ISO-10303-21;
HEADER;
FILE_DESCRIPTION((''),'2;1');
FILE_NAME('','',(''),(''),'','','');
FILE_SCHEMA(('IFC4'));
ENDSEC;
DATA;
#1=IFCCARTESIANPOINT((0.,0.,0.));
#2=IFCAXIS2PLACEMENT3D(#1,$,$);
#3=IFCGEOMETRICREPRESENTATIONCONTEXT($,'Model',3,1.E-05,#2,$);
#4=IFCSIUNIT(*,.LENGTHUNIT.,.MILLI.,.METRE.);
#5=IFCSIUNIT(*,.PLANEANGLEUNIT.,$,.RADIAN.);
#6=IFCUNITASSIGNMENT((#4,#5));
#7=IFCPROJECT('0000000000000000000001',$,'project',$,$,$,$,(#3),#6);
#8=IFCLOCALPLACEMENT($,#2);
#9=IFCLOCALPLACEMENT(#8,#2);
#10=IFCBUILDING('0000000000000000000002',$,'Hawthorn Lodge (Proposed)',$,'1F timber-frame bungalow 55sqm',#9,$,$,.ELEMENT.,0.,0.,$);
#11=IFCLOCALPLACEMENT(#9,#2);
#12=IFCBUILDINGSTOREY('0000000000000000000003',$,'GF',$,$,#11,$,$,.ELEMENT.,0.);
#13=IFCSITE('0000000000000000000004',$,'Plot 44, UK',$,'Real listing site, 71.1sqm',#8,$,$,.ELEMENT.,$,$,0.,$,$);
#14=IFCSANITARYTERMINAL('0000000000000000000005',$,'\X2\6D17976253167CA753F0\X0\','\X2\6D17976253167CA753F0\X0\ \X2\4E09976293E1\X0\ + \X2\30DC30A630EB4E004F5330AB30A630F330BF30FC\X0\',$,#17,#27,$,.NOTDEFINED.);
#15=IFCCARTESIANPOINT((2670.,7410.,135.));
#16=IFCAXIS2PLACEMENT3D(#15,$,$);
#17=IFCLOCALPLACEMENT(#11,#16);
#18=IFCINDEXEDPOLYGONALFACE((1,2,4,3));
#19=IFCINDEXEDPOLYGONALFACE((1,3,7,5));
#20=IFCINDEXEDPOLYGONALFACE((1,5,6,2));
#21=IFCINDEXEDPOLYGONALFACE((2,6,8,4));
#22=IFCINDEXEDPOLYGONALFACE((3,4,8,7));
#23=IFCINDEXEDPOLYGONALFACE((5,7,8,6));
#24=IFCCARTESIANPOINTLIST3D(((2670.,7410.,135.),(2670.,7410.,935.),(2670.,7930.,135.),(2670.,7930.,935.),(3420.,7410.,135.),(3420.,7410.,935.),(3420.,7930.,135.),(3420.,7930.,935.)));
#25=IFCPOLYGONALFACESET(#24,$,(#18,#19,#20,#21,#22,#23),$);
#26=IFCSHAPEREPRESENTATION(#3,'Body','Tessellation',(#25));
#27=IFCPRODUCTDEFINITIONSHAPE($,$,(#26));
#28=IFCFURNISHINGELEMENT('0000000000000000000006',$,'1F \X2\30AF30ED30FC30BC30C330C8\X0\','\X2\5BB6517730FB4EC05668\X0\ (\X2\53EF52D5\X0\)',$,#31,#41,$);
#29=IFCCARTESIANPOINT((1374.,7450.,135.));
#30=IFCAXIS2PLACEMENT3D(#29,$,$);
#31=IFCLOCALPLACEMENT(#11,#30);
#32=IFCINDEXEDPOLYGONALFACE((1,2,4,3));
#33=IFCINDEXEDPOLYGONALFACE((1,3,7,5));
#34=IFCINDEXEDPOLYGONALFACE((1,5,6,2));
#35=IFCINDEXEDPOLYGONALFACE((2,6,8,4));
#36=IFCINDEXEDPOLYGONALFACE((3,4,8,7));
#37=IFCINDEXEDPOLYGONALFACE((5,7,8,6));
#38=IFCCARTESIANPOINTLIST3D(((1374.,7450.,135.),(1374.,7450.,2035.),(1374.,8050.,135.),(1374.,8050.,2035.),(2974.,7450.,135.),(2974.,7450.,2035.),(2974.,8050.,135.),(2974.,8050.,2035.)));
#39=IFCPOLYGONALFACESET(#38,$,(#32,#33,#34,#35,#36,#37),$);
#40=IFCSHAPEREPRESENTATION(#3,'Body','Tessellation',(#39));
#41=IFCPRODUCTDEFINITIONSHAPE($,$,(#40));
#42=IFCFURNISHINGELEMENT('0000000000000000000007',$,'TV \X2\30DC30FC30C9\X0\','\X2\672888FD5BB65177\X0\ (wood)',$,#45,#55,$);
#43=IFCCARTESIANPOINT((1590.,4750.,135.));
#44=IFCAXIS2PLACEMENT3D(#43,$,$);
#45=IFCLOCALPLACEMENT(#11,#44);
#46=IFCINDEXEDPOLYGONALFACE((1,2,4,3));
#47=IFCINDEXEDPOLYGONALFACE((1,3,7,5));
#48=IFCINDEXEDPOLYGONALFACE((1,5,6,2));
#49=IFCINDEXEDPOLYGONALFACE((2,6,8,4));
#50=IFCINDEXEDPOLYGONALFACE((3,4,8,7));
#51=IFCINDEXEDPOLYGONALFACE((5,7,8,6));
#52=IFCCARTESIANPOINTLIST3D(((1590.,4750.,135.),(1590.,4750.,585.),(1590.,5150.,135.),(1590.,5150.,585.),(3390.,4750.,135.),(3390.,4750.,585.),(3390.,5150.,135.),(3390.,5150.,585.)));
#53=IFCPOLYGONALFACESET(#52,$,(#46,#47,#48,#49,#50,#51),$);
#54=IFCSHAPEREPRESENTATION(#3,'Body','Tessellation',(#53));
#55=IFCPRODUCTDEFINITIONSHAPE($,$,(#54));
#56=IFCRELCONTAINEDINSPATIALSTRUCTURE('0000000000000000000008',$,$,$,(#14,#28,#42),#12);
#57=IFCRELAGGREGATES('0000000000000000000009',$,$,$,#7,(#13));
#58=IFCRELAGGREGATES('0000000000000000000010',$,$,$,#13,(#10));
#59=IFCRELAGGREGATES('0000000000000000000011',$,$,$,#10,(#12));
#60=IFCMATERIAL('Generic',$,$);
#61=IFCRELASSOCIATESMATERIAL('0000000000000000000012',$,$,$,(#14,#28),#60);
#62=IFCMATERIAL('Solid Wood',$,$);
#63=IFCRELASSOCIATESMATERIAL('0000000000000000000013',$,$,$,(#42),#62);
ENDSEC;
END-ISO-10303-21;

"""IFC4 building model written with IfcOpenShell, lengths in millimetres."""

from ifc_helpers import new_model, si_unit, frame, frame_2d, origin, place, context, project, spatial, rectangle, extrude, material, element, save


model = new_model("IFC4")

# Units and contexts
model_context = context("Model", 3, precision=1e-05, world=origin())
ifc_project = project(units=[si_unit("LENGTHUNIT", "METRE", prefix="MILLI"), si_unit("PLANEANGLEUNIT", "RADIAN")], contexts=[model_context])

# Site, building, storey
site_placement = place(None, origin())
site = spatial("IfcSite", under=ifc_project, at=site_placement, Name="Plot 44, UK", ObjectType="Real listing site, 71.1sqm", CompositionType="ELEMENT", RefElevation=0.0)
building_placement = place(site_placement, origin())
building = spatial("IfcBuilding", under=site, at=building_placement, Name="Hawthorn Lodge (Proposed)", ObjectType="1F timber-frame bungalow 55sqm", CompositionType="ELEMENT", ElevationOfRefHeight=0.0, ElevationOfTerrain=0.0)
storey_placement = place(building_placement, origin())
storey = spatial("IfcBuildingStorey", under=building, at=storey_placement, Name="GF", CompositionType="ELEMENT", Elevation=0.0)

# Shared definitions
ifc_material_1 = material(Name="Solid Wood")

# Shared definitions
ifc_material_2 = material(Name="Generic")

# Sanitary terminal
sanitary_terminal_1_placement = place(storey_placement, frame((2670.0, 7410.0, 135.0)))
element("IfcSanitaryTerminal", 1, at=sanitary_terminal_1_placement, inside=storey, material=ifc_material_2, Name="洗面化粧台", Description="洗面化粧台 三面鏡 + ボウル一体カウンター", PredefinedType="NOTDEFINED", context=model_context, shape_type="SweptSolid", body=[
    extrude(rectangle(XDim=750.0, YDim=520.0, at=frame_2d((375.0, 260.0))), frame((2670.0, 7410.0, 135.0)), (0.0, 0.0, 1.0), 800.0),
])

# Furnishing elements
furnishing_1_placement = place(storey_placement, frame((1374.0, 7450.0, 135.0)))
element("IfcFurnishingElement", 2, at=furnishing_1_placement, inside=storey, material=ifc_material_2, Name="1F クローゼット", Description="家具・什器 (可動)", context=model_context, shape_type="SweptSolid", body=[
    extrude(rectangle(XDim=1600.0, YDim=600.0, at=frame_2d((800.0, 300.0))), frame((1374.0, 7450.0, 135.0)), (0.0, 0.0, 1.0), 1900.0),
])
furnishing_2_placement = place(storey_placement, frame((1590.0, 4750.0, 135.0)))
element("IfcFurnishingElement", 3, at=furnishing_2_placement, inside=storey, material=ifc_material_1, Name="TV ボード", Description="木製家具 (wood)", context=model_context, shape_type="SweptSolid", body=[
    extrude(rectangle(XDim=1800.0, YDim=400.0, at=frame_2d((900.0, 200.0))), frame((1590.0, 4750.0, 135.0)), (0.0, 0.0, 1.0), 450.0),
])

save(model, "model.ifc")
